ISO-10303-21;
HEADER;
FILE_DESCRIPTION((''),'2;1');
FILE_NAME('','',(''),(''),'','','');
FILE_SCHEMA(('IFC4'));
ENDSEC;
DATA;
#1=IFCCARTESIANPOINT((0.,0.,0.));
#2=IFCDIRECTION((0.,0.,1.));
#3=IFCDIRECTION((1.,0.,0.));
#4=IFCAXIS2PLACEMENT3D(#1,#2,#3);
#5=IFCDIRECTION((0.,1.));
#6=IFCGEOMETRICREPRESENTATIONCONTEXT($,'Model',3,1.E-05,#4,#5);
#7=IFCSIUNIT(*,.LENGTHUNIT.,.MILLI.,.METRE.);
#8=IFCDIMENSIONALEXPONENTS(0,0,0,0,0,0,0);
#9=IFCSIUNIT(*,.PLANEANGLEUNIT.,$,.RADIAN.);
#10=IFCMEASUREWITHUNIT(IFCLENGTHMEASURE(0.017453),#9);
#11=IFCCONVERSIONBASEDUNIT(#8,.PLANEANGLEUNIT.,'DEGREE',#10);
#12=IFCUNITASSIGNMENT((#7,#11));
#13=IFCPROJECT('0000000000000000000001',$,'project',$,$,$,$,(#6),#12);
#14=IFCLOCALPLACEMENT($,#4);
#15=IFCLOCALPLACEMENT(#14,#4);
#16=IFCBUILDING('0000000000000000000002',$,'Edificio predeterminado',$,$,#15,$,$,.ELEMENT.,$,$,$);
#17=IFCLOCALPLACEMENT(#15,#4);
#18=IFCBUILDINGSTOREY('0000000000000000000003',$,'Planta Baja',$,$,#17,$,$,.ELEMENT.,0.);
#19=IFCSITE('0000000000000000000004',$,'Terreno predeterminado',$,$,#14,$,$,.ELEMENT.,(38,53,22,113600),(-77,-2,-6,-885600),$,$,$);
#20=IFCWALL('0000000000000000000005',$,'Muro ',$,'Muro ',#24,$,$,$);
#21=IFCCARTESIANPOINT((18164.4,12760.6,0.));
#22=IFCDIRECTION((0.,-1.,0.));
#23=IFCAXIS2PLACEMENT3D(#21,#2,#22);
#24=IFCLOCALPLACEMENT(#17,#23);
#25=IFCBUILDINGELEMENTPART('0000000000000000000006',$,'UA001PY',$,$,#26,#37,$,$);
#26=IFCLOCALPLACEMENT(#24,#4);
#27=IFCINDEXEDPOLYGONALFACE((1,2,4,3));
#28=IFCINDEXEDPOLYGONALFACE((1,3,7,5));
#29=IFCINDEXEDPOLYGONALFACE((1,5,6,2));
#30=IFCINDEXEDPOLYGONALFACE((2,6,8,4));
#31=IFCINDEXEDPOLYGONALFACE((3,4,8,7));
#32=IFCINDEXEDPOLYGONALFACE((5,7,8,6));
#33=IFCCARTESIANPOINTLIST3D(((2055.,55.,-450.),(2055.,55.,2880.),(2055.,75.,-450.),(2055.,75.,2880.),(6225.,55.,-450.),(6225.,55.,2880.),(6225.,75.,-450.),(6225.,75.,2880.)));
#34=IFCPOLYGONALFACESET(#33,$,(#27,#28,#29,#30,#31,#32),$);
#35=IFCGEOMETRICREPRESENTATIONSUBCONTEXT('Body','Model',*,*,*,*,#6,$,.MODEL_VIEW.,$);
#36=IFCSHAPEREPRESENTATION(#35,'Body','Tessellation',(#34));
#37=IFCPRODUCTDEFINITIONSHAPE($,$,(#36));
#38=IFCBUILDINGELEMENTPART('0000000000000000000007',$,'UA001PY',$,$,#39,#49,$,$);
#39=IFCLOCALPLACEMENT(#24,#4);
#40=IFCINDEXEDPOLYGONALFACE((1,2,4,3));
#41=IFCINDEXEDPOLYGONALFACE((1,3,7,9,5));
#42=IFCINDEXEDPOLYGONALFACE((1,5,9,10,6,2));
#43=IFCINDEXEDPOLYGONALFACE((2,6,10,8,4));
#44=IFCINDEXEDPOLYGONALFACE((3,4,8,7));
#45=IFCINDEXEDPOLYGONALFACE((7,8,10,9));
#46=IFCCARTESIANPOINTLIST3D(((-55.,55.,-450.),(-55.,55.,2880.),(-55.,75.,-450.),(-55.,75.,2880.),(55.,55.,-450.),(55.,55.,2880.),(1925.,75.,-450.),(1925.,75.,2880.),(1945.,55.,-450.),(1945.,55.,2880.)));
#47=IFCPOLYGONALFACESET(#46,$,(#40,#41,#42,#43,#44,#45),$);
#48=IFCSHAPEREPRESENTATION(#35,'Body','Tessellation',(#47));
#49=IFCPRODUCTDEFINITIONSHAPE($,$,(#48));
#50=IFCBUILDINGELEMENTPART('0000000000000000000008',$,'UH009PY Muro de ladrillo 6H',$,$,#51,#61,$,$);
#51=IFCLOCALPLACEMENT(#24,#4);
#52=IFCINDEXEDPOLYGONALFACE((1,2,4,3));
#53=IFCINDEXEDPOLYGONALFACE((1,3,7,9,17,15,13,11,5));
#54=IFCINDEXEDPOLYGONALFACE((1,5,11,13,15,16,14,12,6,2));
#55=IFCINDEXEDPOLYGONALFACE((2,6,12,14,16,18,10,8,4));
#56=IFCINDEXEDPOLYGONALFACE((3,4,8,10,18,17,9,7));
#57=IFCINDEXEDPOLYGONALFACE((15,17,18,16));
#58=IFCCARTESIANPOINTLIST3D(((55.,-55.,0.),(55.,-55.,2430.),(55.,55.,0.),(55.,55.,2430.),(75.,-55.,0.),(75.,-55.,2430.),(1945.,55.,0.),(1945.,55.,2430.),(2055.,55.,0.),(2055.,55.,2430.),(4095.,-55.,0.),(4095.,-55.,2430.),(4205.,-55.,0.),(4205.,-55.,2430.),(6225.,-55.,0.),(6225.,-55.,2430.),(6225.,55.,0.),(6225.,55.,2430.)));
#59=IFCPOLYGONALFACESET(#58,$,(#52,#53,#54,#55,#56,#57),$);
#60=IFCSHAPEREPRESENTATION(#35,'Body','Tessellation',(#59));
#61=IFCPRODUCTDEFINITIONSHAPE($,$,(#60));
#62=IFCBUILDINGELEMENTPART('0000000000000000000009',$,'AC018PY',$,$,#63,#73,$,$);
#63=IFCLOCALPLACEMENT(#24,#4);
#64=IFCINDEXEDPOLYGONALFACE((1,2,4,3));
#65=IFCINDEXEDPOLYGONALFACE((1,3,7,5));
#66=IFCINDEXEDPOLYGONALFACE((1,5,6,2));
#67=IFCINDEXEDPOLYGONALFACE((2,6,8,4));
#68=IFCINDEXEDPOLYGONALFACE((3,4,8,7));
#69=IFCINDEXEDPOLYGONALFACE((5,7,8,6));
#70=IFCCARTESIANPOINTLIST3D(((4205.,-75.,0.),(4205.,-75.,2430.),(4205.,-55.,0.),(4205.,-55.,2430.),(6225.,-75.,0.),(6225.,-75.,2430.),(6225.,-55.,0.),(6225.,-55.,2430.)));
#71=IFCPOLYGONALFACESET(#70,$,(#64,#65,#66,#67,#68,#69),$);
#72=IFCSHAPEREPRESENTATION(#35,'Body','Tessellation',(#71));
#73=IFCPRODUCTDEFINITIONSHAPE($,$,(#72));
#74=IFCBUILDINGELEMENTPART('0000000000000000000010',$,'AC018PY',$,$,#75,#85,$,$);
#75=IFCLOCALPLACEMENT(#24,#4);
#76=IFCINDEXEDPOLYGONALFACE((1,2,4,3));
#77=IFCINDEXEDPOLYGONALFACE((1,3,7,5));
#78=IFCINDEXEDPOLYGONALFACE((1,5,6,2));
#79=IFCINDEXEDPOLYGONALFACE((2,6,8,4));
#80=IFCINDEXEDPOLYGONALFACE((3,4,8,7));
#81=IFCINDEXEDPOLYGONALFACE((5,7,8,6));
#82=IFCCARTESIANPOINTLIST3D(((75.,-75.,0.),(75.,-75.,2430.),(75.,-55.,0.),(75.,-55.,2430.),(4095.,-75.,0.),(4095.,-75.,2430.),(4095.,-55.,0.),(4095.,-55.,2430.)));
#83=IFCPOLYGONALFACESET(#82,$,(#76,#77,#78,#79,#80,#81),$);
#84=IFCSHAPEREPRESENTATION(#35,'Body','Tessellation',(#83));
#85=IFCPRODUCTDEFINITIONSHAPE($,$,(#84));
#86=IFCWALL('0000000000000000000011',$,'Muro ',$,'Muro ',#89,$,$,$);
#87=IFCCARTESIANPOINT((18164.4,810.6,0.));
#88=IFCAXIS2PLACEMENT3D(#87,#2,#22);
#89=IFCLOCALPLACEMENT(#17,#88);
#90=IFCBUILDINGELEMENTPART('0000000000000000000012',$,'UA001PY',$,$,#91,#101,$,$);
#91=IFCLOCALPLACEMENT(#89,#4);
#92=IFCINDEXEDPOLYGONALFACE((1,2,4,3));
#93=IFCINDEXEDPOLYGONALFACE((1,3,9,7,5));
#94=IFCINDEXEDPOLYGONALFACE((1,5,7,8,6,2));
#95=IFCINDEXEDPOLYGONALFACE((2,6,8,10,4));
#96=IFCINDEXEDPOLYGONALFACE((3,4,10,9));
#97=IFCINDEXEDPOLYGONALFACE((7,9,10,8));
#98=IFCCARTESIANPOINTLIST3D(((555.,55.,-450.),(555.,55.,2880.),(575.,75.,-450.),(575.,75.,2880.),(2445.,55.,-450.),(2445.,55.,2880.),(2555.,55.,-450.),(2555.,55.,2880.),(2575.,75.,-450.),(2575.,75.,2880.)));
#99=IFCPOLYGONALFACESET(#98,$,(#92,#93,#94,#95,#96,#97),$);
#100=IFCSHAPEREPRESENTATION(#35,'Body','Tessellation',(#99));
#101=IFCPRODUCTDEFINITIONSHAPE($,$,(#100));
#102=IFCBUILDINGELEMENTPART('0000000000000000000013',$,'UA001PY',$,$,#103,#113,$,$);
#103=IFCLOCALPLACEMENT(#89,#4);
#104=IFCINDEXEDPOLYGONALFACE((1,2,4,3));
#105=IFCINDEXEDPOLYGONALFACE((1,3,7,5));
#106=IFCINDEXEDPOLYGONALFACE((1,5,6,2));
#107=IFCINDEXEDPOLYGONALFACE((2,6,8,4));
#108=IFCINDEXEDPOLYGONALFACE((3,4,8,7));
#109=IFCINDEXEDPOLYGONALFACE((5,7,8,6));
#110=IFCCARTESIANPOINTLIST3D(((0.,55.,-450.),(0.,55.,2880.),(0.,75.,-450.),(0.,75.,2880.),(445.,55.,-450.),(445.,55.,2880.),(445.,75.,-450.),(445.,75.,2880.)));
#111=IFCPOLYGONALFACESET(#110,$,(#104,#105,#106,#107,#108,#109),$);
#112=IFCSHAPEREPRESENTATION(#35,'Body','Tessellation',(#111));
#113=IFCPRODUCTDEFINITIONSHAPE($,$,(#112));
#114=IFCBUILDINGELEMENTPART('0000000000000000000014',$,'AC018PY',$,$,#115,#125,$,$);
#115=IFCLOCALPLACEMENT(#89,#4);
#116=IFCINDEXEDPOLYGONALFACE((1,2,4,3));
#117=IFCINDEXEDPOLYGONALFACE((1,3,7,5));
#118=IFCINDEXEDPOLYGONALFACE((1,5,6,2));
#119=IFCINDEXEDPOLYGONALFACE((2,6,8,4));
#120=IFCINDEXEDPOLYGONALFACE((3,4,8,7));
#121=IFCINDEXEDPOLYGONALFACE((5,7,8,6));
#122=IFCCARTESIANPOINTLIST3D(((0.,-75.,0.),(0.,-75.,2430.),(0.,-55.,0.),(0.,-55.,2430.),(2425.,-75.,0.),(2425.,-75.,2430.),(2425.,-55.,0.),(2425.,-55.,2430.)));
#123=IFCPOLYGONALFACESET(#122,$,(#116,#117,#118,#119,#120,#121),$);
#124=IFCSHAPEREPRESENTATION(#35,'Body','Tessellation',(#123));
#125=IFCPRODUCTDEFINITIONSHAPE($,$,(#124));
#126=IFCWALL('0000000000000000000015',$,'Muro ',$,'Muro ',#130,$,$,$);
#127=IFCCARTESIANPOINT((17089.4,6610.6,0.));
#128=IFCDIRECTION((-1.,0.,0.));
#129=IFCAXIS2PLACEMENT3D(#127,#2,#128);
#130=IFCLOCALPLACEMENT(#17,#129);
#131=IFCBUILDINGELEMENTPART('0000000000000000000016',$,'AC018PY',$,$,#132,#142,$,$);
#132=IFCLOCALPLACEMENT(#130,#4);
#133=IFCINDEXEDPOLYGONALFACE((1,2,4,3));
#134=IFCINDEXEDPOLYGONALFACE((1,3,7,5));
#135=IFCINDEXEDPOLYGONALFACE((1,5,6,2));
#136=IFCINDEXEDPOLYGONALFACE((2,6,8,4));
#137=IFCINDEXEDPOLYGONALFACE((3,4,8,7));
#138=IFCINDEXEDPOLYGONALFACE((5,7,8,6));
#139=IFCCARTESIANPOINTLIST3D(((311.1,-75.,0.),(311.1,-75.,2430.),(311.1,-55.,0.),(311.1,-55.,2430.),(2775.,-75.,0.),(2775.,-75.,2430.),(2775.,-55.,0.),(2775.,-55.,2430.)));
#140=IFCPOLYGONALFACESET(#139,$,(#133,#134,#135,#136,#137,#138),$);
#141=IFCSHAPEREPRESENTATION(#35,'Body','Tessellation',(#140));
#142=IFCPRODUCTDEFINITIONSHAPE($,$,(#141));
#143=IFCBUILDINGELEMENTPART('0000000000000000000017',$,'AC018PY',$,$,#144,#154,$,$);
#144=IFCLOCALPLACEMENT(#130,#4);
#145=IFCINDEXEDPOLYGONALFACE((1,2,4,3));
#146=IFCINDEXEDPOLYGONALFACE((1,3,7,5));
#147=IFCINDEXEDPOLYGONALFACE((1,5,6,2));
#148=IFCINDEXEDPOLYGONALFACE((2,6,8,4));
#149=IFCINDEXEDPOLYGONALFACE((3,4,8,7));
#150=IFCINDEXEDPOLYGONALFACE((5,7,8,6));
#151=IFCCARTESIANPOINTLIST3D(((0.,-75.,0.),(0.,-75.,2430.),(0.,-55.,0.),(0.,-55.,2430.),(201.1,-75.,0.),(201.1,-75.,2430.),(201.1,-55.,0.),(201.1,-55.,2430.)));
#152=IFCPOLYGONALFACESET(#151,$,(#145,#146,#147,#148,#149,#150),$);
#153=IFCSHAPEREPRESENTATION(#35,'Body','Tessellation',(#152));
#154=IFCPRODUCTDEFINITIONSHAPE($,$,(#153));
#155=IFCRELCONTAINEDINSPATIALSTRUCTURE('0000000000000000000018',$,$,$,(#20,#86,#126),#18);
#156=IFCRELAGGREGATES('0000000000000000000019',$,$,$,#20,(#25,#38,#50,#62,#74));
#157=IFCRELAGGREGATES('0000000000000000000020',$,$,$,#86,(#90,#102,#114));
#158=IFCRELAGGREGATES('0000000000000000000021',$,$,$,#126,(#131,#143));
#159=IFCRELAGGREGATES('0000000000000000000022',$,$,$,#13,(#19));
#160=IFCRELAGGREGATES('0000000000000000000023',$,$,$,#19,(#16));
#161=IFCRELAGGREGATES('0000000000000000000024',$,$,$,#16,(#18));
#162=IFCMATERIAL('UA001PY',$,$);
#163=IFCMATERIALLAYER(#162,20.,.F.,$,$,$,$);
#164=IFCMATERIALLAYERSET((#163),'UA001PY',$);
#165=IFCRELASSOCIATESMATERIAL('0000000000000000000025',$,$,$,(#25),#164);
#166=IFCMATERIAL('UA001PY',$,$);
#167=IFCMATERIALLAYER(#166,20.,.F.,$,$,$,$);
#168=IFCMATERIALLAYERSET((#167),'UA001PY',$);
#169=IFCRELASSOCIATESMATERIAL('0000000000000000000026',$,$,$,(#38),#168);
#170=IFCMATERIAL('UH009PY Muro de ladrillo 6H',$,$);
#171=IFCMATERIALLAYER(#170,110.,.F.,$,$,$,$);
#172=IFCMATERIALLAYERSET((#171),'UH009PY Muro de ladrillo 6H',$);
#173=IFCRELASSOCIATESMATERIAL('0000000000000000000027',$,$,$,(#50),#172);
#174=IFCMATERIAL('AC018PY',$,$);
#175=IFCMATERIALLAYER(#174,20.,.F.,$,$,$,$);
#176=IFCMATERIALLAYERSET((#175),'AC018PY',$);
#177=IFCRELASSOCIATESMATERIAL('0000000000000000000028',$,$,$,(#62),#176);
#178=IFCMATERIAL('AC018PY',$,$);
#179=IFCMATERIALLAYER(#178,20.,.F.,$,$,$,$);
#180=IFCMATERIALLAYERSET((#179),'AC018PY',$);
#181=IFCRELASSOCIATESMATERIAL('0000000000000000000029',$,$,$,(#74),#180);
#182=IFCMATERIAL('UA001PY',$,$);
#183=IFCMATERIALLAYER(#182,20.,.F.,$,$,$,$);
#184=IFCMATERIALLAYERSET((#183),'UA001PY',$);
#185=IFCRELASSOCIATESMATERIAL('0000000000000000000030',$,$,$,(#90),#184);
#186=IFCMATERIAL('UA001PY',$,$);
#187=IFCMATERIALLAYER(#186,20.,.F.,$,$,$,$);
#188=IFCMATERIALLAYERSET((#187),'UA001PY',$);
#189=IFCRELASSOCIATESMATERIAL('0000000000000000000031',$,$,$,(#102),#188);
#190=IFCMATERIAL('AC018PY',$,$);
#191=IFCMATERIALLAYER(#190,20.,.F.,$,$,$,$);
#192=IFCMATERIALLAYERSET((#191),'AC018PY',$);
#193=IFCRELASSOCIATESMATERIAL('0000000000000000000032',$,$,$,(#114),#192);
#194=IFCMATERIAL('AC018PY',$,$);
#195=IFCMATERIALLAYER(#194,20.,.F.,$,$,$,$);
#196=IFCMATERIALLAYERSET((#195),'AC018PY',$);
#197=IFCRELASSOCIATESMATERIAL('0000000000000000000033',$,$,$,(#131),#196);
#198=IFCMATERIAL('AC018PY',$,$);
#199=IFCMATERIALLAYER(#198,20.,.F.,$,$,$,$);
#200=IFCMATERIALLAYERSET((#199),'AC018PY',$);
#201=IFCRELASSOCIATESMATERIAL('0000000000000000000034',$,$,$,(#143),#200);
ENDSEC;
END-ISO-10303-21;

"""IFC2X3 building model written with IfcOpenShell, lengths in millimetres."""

from ifc_helpers import new_model, entity, si_unit, converted_unit, direction, frame, origin_with_axes, place, context, subcontext, project, spatial, polyline, outline, extrude, material, layer, layer_set, layer_usage, element, aggregate, save


model = new_model("IFC2X3")

# Units and contexts
model_context = context("Model", 3, precision=1e-05, world=origin_with_axes(), true_north=direction((0.0, 1.0)))
body_context = subcontext(model_context, "Body", "Model", "MODEL_VIEW")
ifc_project = project(units=[si_unit("LENGTHUNIT", "METRE", prefix="MILLI"), converted_unit("PLANEANGLEUNIT", "DEGREE", entity("IfcLengthMeasure", 0.017453), si_unit("PLANEANGLEUNIT", "RADIAN"), dimensions=[0, 0, 0, 0, 0, 0, 0])], contexts=[model_context])

# Site, building, storey
site_placement = place(None, origin_with_axes())
site = spatial("IfcSite", under=ifc_project, at=site_placement, Name="Terreno predeterminado", CompositionType="ELEMENT", RefLatitude=(38, 53, 22, 113600), RefLongitude=(-77, -2, -6, -885600))
building_placement = place(site_placement, origin_with_axes())
building = spatial("IfcBuilding", under=site, at=building_placement, Name="Edificio predeterminado", CompositionType="ELEMENT")
storey_placement = place(building_placement, origin_with_axes())
storey = spatial("IfcBuildingStorey", under=building, at=storey_placement, Name="Planta Baja", CompositionType="ELEMENT", Elevation=0.0)

# Walls, building element parts
wall_1_placement = place(storey_placement, frame((18164.4, 12760.6, 0.0), z_axis=(0.0, 0.0, 1.0), x_axis=(0.0, -1.0, 0.0)))
wall_1 = element("IfcWall", 1, at=wall_1_placement, inside=storey, Name="Muro ", ObjectType="Muro ")
ifc_material_1 = material(Name="UA001PY")
ifc_layer_1 = layer(ifc_material_1, 20.0, ventilated=False)
ifc_layer_set_1 = layer_set([ifc_layer_1], Name="UA001PY")
ifc_layer_usage_1 = layer_usage(ifc_layer_set_1, "AXIS2", "NEGATIVE", -75.0)
building_element_part_1_placement = place(wall_1_placement, origin_with_axes())
building_element_part_1 = element("IfcBuildingElementPart", 2, at=building_element_part_1_placement, material=ifc_layer_usage_1, Name="UA001PY", context=body_context, shape_type="SweptSolid", body=[
    extrude(outline(polyline([(6225.0, 75.0), (6225.0, 55.0), (2055.0, 55.0), (2055.0, 75.0), (6225.0, 75.0)])), frame((0.0, 0.0, -450.0), z_axis=(0.0, 0.0, 1.0), x_axis=(1.0, 0.0, 0.0)), (0.0, 0.0, 1.0), 3330.0),
])
ifc_material_2 = material(Name="UA001PY")
ifc_layer_2 = layer(ifc_material_2, 20.0, ventilated=False)
ifc_layer_set_2 = layer_set([ifc_layer_2], Name="UA001PY")
ifc_layer_usage_2 = layer_usage(ifc_layer_set_2, "AXIS2", "NEGATIVE", -75.0)
building_element_part_2_placement = place(wall_1_placement, origin_with_axes())
building_element_part_2 = element("IfcBuildingElementPart", 3, at=building_element_part_2_placement, material=ifc_layer_usage_2, Name="UA001PY", context=body_context, shape_type="SweptSolid", body=[
    extrude(outline(polyline([(1925.0, 75.0), (1945.0, 55.0), (55.0, 55.0), (-55.0, 55.0), (-55.0, 75.0), (1925.0, 75.0)])), frame((0.0, 0.0, -450.0), z_axis=(0.0, 0.0, 1.0), x_axis=(1.0, 0.0, 0.0)), (0.0, 0.0, 1.0), 3330.0),
])
ifc_material_3 = material(Name="UH009PY Muro de ladrillo 6H")
ifc_layer_3 = layer(ifc_material_3, 110.0, ventilated=False)
ifc_layer_set_3 = layer_set([ifc_layer_3], Name="UH009PY Muro de ladrillo 6H")
ifc_layer_usage_3 = layer_usage(ifc_layer_set_3, "AXIS2", "NEGATIVE", -55.0)
building_element_part_3_placement = place(wall_1_placement, origin_with_axes())
building_element_part_3 = element("IfcBuildingElementPart", 4, at=building_element_part_3_placement, material=ifc_layer_usage_3, Name="UH009PY Muro de ladrillo 6H", context=body_context, shape_type="SweptSolid", body=[
    extrude(outline(polyline([(6225.0, 55.0), (6225.0, -55.0), (4205.0, -55.0), (4095.0, -55.0), (75.0, -55.0), (55.0, -55.0), (55.0, 55.0), (1945.0, 55.0), (2055.0, 55.0), (6225.0, 55.0)])), origin_with_axes(), (0.0, 0.0, 1.0), 2430.0),
])
ifc_material_4 = material(Name="AC018PY")
ifc_layer_4 = layer(ifc_material_4, 20.0, ventilated=False)
ifc_layer_set_4 = layer_set([ifc_layer_4], Name="AC018PY")
ifc_layer_usage_4 = layer_usage(ifc_layer_set_4, "AXIS2", "NEGATIVE", 55.0)
building_element_part_4_placement = place(wall_1_placement, origin_with_axes())
building_element_part_4 = element("IfcBuildingElementPart", 5, at=building_element_part_4_placement, material=ifc_layer_usage_4, Name="AC018PY", context=body_context, shape_type="SweptSolid", body=[
    extrude(outline(polyline([(6225.0, -55.0), (6225.0, -75.0), (4205.0, -75.0), (4205.0, -55.0), (6225.0, -55.0)])), origin_with_axes(), (0.0, 0.0, 1.0), 2430.0),
])
ifc_material_5 = material(Name="AC018PY")
ifc_layer_5 = layer(ifc_material_5, 20.0, ventilated=False)
ifc_layer_set_5 = layer_set([ifc_layer_5], Name="AC018PY")
ifc_layer_usage_5 = layer_usage(ifc_layer_set_5, "AXIS2", "NEGATIVE", 55.0)
building_element_part_5_placement = place(wall_1_placement, origin_with_axes())
building_element_part_5 = element("IfcBuildingElementPart", 6, at=building_element_part_5_placement, material=ifc_layer_usage_5, Name="AC018PY", context=body_context, shape_type="SweptSolid", body=[
    extrude(outline(polyline([(4095.0, -55.0), (4095.0, -75.0), (75.0, -75.0), (75.0, -55.0), (4095.0, -55.0)])), origin_with_axes(), (0.0, 0.0, 1.0), 2430.0),
])
aggregate(wall_1, [building_element_part_1, building_element_part_2, building_element_part_3, building_element_part_4, building_element_part_5])
wall_2_placement = place(storey_placement, frame((18164.4, 810.6, 0.0), z_axis=(0.0, 0.0, 1.0), x_axis=(0.0, -1.0, 0.0)))
wall_2 = element("IfcWall", 7, at=wall_2_placement, inside=storey, Name="Muro ", ObjectType="Muro ")
ifc_material_6 = material(Name="UA001PY")
ifc_layer_6 = layer(ifc_material_6, 20.0, ventilated=False)
ifc_layer_set_6 = layer_set([ifc_layer_6], Name="UA001PY")
ifc_layer_usage_6 = layer_usage(ifc_layer_set_6, "AXIS2", "NEGATIVE", -75.0)
building_element_part_6_placement = place(wall_2_placement, origin_with_axes())
building_element_part_6 = element("IfcBuildingElementPart", 8, at=building_element_part_6_placement, material=ifc_layer_usage_6, Name="UA001PY", context=body_context, shape_type="SweptSolid", body=[
    extrude(outline(polyline([(2575.0, 75.0), (2555.0, 55.0), (2445.0, 55.0), (555.0, 55.0), (575.0, 75.0), (2575.0, 75.0)])), frame((0.0, 0.0, -450.0), z_axis=(0.0, 0.0, 1.0), x_axis=(1.0, 0.0, 0.0)), (0.0, 0.0, 1.0), 3330.0),
])
ifc_material_7 = material(Name="UA001PY")
ifc_layer_7 = layer(ifc_material_7, 20.0, ventilated=False)
ifc_layer_set_7 = layer_set([ifc_layer_7], Name="UA001PY")
ifc_layer_usage_7 = layer_usage(ifc_layer_set_7, "AXIS2", "NEGATIVE", -75.0)
building_element_part_7_placement = place(wall_2_placement, origin_with_axes())
building_element_part_7 = element("IfcBuildingElementPart", 9, at=building_element_part_7_placement, material=ifc_layer_usage_7, Name="UA001PY", context=body_context, shape_type="SweptSolid", body=[
    extrude(outline(polyline([(445.0, 75.0), (445.0, 55.0), (0.0, 55.0), (0.0, 75.0), (445.0, 75.0)])), frame((0.0, 0.0, -450.0), z_axis=(0.0, 0.0, 1.0), x_axis=(1.0, 0.0, 0.0)), (0.0, 0.0, 1.0), 3330.0),
])
ifc_material_8 = material(Name="AC018PY")
ifc_layer_8 = layer(ifc_material_8, 20.0, ventilated=False)
ifc_layer_set_8 = layer_set([ifc_layer_8], Name="AC018PY")
ifc_layer_usage_8 = layer_usage(ifc_layer_set_8, "AXIS2", "NEGATIVE", 55.0)
building_element_part_8_placement = place(wall_2_placement, origin_with_axes())
building_element_part_8 = element("IfcBuildingElementPart", 10, at=building_element_part_8_placement, material=ifc_layer_usage_8, Name="AC018PY", context=body_context, shape_type="SweptSolid", body=[
    extrude(outline(polyline([(2425.0, -55.0), (2425.0, -75.0), (0.0, -75.0), (0.0, -55.0), (2425.0, -55.0)])), origin_with_axes(), (0.0, 0.0, 1.0), 2430.0),
])
aggregate(wall_2, [building_element_part_6, building_element_part_7, building_element_part_8])
wall_3_placement = place(storey_placement, frame((17089.4, 6610.6, 0.0), z_axis=(0.0, 0.0, 1.0), x_axis=(-1.0, 0.0, 0.0)))
wall_3 = element("IfcWall", 11, at=wall_3_placement, inside=storey, Name="Muro ", ObjectType="Muro ")
ifc_material_9 = material(Name="AC018PY")
ifc_layer_9 = layer(ifc_material_9, 20.0, ventilated=False)
ifc_layer_set_9 = layer_set([ifc_layer_9], Name="AC018PY")
ifc_layer_usage_9 = layer_usage(ifc_layer_set_9, "AXIS2", "NEGATIVE", 55.0)
building_element_part_9_placement = place(wall_3_placement, origin_with_axes())
building_element_part_9 = element("IfcBuildingElementPart", 12, at=building_element_part_9_placement, material=ifc_layer_usage_9, Name="AC018PY", context=body_context, shape_type="SweptSolid", body=[
    extrude(outline(polyline([(2775.0, -55.0), (2775.0, -75.0), (311.1, -75.0), (311.1, -55.0), (2775.0, -55.0)])), origin_with_axes(), (0.0, 0.0, 1.0), 2430.0),
])
ifc_material_10 = material(Name="AC018PY")
ifc_layer_10 = layer(ifc_material_10, 20.0, ventilated=False)
ifc_layer_set_10 = layer_set([ifc_layer_10], Name="AC018PY")
ifc_layer_usage_10 = layer_usage(ifc_layer_set_10, "AXIS2", "NEGATIVE", 55.0)
building_element_part_10_placement = place(wall_3_placement, origin_with_axes())
building_element_part_10 = element("IfcBuildingElementPart", 13, at=building_element_part_10_placement, material=ifc_layer_usage_10, Name="AC018PY", context=body_context, shape_type="SweptSolid", body=[
    extrude(outline(polyline([(201.1, -55.0), (201.1, -75.0), (0.0, -75.0), (0.0, -55.0), (201.1, -55.0)])), origin_with_axes(), (0.0, 0.0, 1.0), 2430.0),
])
aggregate(wall_3, [building_element_part_9, building_element_part_10])

save(model, "model.ifc")
